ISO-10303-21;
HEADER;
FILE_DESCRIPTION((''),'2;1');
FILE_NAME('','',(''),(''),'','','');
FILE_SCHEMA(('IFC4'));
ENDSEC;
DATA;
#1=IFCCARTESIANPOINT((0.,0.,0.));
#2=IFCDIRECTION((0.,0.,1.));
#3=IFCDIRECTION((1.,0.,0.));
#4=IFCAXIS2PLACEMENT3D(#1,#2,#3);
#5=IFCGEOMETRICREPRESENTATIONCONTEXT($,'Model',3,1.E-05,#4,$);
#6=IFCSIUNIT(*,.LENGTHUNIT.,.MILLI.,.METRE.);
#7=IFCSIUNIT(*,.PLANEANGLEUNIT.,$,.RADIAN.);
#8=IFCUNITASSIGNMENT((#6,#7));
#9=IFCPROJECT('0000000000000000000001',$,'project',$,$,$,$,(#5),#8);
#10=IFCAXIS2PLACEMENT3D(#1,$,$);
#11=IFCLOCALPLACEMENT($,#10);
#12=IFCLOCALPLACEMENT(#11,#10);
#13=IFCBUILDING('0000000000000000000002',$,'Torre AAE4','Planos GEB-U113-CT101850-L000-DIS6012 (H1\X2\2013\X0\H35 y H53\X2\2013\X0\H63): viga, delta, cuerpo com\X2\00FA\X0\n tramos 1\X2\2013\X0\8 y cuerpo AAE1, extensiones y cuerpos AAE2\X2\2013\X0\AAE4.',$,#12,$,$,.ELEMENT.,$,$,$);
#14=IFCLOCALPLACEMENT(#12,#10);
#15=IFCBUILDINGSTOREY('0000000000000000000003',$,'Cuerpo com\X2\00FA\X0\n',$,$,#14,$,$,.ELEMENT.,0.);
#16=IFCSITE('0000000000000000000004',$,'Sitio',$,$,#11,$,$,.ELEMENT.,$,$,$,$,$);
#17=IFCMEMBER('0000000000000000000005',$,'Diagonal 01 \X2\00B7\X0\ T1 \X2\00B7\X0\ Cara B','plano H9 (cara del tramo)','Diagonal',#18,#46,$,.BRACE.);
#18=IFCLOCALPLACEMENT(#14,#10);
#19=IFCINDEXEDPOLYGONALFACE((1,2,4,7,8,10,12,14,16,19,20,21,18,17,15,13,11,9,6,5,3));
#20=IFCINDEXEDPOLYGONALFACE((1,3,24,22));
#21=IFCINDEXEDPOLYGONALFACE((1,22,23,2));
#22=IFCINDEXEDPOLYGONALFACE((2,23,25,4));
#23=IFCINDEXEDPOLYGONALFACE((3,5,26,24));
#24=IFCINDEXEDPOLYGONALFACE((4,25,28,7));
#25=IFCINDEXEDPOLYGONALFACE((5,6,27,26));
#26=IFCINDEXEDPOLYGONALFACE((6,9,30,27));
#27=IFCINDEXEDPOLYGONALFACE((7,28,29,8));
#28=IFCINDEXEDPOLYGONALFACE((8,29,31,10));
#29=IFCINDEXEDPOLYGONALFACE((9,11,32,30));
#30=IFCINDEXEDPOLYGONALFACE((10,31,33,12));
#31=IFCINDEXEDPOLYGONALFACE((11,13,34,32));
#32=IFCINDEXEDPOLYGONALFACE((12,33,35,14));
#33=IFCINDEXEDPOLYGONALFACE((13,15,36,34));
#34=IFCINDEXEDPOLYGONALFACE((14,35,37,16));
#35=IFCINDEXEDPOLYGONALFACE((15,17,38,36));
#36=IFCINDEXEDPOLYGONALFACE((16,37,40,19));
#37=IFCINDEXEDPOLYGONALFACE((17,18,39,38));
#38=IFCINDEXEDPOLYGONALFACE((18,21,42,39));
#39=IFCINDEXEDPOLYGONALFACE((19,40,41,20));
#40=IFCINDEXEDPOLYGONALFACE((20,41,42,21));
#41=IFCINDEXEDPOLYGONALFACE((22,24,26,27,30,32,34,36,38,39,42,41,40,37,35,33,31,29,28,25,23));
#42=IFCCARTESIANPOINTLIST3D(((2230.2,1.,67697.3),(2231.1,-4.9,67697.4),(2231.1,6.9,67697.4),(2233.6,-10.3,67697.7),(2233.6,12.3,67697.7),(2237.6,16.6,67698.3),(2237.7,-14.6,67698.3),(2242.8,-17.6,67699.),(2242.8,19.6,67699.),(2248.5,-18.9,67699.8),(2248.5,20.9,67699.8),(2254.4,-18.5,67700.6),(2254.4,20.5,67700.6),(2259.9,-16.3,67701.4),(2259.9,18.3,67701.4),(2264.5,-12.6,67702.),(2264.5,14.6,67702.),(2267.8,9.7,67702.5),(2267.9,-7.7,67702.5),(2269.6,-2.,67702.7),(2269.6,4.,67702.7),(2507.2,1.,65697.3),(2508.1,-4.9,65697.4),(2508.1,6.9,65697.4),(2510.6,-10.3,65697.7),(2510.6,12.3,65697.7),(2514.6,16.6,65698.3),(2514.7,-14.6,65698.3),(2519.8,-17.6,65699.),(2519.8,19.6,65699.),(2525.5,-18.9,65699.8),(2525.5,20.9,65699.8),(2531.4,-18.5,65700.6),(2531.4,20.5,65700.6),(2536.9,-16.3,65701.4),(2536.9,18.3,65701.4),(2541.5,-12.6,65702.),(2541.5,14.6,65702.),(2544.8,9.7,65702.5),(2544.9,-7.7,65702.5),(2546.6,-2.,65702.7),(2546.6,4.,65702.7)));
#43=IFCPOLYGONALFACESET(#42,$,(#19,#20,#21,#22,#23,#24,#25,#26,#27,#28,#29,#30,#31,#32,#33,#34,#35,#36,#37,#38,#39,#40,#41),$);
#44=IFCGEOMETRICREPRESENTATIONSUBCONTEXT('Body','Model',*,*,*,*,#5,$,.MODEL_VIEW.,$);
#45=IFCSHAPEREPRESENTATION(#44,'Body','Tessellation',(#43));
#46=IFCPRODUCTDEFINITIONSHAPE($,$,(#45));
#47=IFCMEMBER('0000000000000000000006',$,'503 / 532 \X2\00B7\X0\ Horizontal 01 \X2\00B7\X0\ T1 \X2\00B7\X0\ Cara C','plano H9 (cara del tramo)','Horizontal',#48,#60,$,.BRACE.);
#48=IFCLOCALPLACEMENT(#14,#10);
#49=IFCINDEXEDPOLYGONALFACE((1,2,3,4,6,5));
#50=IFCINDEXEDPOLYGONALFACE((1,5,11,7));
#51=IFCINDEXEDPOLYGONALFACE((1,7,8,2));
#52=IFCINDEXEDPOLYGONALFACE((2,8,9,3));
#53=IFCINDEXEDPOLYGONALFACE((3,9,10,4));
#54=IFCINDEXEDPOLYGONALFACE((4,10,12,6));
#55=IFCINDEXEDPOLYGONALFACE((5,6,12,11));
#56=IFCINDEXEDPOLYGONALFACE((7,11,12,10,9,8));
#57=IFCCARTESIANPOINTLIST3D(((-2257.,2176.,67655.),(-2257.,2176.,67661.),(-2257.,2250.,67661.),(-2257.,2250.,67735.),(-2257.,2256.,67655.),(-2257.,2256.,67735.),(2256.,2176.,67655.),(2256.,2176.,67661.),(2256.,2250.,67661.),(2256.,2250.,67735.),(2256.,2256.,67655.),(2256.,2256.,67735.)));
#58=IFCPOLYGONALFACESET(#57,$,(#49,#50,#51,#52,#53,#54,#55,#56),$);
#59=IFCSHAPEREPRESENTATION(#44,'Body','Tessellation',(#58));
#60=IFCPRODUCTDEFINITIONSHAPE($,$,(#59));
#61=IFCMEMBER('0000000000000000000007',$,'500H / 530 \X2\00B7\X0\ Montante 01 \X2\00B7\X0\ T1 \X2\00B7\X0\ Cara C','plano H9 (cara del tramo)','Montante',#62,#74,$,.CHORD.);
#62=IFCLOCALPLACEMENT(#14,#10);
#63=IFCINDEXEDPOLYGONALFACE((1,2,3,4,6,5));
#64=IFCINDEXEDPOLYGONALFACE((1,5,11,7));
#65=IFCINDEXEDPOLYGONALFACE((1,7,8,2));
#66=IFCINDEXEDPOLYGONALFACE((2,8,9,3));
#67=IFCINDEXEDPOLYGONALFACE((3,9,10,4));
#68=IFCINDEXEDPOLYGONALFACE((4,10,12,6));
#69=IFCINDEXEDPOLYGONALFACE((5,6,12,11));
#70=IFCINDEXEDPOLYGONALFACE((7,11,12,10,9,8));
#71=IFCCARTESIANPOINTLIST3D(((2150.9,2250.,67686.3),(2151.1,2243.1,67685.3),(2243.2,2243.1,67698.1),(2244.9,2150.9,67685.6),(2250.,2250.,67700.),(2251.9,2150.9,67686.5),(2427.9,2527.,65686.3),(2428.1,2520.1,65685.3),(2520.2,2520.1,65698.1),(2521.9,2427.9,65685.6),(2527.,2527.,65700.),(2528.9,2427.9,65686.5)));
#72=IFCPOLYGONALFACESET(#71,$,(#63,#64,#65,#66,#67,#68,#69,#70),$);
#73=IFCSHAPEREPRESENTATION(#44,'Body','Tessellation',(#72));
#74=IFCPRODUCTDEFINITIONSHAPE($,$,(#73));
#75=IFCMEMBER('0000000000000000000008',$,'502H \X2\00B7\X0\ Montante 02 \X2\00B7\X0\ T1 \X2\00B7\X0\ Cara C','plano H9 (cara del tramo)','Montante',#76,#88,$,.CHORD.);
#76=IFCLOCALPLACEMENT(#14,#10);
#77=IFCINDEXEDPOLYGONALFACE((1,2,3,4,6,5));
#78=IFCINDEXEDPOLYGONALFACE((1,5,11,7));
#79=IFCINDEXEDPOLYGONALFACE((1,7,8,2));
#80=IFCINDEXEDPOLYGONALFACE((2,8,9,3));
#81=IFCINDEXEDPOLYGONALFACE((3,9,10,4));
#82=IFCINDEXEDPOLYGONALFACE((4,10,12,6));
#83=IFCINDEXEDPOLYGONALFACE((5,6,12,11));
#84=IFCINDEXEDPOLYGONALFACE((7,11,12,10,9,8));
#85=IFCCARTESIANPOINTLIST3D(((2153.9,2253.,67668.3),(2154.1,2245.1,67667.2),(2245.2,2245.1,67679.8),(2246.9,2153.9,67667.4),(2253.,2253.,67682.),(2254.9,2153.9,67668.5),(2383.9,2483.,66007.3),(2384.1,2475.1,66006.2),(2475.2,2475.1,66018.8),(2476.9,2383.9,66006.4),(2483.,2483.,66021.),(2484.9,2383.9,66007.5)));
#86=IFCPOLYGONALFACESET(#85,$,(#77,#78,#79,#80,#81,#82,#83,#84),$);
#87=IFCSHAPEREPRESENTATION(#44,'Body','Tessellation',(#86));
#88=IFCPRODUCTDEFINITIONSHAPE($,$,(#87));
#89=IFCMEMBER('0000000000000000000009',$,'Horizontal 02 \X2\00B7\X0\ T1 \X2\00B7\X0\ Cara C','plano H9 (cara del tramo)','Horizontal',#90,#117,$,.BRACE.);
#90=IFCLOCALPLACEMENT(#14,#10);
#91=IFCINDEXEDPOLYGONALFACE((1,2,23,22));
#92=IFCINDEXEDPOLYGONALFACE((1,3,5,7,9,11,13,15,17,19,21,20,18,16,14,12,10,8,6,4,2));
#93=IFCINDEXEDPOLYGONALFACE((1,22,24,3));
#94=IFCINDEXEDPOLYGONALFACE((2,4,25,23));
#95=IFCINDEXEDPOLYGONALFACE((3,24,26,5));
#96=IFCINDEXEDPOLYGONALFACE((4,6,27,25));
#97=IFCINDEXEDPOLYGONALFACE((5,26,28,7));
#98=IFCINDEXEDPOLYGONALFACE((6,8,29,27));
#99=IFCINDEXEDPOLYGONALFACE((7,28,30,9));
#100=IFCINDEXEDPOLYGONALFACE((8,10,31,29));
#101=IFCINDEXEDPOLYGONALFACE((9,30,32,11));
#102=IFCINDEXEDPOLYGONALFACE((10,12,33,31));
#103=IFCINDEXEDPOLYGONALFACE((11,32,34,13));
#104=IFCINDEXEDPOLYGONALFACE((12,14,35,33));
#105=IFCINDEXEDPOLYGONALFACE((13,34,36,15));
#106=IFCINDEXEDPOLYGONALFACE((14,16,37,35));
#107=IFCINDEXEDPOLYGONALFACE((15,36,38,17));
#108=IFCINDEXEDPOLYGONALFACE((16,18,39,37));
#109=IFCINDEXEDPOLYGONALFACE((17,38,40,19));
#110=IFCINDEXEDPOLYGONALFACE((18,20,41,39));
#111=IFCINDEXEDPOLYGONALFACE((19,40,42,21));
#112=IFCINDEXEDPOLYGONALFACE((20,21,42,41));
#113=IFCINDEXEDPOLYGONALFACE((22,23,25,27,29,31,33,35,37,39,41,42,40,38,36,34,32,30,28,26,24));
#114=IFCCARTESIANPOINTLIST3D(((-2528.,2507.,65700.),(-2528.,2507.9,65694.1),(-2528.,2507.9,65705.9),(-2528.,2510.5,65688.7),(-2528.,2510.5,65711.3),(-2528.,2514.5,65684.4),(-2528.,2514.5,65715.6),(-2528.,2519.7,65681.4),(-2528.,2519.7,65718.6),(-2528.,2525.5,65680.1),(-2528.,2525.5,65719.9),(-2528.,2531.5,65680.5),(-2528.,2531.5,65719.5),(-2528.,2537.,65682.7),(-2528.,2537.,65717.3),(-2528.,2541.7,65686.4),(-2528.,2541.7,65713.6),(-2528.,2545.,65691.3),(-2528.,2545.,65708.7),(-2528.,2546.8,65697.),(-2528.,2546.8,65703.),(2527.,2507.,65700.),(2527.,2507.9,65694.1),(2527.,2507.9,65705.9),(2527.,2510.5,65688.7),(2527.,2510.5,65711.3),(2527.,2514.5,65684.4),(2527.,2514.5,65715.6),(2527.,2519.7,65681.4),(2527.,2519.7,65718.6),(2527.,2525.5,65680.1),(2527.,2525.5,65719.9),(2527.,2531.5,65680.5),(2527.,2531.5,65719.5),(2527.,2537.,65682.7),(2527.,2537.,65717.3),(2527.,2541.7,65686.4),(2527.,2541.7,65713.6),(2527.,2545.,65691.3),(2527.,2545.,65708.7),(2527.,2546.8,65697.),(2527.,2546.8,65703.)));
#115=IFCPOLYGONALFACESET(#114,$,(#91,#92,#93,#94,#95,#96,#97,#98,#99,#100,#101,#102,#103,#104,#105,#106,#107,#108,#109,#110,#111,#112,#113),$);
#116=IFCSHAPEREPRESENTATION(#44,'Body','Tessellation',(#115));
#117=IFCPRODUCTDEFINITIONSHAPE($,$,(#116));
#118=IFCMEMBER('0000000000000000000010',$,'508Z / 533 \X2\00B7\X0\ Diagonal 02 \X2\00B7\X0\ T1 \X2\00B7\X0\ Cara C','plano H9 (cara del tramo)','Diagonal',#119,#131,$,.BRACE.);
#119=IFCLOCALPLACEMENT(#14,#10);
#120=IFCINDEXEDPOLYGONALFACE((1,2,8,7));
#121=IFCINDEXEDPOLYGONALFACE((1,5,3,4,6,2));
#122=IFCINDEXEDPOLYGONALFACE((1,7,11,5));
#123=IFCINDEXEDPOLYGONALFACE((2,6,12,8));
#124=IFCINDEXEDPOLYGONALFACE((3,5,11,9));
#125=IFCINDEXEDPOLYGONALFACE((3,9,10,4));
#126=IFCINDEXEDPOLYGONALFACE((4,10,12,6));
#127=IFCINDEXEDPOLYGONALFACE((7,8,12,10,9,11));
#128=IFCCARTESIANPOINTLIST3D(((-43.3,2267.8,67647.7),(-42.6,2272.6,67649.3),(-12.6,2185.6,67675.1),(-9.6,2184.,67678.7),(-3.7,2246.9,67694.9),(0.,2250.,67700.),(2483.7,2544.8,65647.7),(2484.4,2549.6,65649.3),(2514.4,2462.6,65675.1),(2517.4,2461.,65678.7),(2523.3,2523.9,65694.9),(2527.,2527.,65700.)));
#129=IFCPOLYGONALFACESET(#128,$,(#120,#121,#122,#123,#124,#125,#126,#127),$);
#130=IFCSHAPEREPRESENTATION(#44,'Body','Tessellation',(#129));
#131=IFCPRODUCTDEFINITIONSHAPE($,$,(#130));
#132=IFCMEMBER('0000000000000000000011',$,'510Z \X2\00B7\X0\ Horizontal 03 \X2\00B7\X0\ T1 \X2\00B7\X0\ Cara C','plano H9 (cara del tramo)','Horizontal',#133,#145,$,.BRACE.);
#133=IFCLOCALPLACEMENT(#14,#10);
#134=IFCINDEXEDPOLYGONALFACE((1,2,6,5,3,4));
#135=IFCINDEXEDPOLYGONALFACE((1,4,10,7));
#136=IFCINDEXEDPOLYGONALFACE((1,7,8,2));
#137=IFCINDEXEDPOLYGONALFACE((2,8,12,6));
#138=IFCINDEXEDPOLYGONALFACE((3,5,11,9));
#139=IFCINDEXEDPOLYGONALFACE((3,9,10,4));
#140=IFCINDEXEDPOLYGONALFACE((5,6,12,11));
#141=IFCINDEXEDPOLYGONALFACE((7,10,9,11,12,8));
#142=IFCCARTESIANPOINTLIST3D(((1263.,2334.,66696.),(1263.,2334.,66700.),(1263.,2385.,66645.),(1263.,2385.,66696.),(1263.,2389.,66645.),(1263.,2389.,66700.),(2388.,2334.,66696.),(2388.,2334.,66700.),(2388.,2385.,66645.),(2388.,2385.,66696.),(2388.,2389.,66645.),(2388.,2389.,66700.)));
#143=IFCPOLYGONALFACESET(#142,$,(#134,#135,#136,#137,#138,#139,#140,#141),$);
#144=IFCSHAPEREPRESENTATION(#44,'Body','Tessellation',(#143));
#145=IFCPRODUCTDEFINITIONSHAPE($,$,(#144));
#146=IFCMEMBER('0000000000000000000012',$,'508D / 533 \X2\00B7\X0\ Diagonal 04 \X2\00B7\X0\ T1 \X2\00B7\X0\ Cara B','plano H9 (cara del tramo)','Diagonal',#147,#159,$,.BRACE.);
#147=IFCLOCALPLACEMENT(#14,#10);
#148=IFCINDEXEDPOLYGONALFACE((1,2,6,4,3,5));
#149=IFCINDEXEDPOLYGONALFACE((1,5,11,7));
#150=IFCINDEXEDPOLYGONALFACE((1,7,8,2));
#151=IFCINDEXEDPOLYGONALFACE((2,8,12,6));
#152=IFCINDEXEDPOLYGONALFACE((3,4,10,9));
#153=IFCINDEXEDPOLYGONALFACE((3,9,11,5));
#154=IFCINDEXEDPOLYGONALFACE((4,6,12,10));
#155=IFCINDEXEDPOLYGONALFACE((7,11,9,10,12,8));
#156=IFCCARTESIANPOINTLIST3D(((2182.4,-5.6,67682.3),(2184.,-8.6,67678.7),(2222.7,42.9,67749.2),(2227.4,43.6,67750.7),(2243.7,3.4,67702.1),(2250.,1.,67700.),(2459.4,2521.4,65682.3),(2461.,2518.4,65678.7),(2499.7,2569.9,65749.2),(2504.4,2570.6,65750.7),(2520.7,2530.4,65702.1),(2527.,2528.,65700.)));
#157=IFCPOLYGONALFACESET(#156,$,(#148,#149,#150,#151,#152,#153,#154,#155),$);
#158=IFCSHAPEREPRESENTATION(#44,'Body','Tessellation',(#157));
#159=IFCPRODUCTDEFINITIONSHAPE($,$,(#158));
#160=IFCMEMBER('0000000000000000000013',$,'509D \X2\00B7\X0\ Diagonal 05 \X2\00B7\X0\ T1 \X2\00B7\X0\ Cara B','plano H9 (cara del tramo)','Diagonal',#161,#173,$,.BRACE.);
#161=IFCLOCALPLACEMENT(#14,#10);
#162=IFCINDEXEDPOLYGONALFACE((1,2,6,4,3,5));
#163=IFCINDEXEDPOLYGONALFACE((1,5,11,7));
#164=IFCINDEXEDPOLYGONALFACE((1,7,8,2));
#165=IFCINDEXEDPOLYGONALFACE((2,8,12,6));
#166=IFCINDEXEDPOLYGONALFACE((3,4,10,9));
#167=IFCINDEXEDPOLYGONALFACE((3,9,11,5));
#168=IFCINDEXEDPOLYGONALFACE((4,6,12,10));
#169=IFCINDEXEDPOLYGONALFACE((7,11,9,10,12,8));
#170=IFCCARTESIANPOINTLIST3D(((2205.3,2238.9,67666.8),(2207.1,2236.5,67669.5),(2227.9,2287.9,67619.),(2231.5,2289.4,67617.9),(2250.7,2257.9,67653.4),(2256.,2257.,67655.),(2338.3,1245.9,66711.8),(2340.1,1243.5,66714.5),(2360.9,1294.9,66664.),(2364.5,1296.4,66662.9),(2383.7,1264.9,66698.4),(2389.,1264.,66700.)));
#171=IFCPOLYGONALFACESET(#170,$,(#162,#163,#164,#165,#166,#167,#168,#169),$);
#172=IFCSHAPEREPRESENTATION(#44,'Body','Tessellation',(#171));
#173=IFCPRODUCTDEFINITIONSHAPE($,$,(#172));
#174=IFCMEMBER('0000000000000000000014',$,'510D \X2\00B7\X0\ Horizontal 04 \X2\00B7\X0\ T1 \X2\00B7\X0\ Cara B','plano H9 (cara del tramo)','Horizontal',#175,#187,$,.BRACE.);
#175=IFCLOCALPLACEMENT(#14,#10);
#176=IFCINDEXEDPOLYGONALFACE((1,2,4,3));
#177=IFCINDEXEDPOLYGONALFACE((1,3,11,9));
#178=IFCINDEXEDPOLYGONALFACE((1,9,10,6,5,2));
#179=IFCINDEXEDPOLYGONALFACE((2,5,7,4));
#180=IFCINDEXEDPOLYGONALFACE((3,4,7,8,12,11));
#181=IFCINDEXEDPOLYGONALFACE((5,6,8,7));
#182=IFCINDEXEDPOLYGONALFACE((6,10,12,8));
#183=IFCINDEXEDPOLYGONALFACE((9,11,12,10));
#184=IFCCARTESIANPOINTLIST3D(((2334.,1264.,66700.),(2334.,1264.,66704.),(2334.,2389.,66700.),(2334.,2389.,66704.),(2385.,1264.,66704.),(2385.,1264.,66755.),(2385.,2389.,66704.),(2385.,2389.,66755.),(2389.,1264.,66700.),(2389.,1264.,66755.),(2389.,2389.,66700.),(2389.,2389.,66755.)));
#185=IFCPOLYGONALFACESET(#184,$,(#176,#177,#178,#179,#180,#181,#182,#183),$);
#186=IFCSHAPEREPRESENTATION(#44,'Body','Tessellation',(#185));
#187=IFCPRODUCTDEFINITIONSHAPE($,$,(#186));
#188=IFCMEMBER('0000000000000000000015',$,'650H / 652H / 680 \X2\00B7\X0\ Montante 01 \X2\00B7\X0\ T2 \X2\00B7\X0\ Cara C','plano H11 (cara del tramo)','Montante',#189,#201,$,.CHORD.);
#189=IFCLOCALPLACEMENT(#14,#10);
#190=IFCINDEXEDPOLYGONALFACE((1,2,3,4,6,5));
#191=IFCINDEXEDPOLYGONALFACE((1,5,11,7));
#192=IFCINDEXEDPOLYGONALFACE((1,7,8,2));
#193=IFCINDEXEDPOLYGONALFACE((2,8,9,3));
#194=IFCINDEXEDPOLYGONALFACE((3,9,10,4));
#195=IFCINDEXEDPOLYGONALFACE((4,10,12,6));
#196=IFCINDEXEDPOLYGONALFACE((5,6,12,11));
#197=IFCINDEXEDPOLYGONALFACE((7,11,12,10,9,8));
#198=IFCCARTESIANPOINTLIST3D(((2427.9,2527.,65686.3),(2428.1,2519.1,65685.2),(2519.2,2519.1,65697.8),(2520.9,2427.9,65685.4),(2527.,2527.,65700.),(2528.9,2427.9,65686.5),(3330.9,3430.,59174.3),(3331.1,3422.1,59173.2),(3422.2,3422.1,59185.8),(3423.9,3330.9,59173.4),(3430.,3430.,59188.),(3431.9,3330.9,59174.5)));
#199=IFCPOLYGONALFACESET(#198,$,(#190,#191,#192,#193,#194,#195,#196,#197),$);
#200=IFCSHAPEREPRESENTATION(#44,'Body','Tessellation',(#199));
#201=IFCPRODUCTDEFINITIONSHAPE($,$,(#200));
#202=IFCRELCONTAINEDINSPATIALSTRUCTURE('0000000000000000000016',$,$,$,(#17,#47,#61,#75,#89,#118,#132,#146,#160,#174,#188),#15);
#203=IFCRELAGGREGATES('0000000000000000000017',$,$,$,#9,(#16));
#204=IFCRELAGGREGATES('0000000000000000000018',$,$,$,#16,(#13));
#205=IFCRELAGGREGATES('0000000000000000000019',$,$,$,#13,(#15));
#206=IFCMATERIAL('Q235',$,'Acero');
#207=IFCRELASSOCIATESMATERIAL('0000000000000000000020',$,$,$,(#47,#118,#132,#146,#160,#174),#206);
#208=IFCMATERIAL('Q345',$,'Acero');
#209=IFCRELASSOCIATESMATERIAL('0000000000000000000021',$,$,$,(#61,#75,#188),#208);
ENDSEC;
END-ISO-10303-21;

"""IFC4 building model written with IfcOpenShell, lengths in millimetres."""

from ifc_helpers import new_model, si_unit, frame, frame_2d, origin, origin_with_axes, place, context, subcontext, project, spatial, circle, l_section, extrude, material, element, save


model = new_model("IFC4")

# Units and contexts
model_context = context("Model", 3, precision=1e-05, world=origin_with_axes())
body_context = subcontext(model_context, "Body", "Model", "MODEL_VIEW")
ifc_project = project(units=[si_unit("LENGTHUNIT", "METRE", prefix="MILLI"), si_unit("PLANEANGLEUNIT", "RADIAN")], contexts=[model_context])

# Site, building, storey
site_placement = place(None, origin())
site = spatial("IfcSite", under=ifc_project, at=site_placement, Name="Sitio", CompositionType="ELEMENT")
building_placement = place(site_placement, origin())
building = spatial("IfcBuilding", under=site, at=building_placement, Name="Torre AAE4", Description="Planos GEB-U113-CT101850-L000-DIS6012 (H1–H35 y H53–H63): viga, delta, cuerpo común tramos 1–8 y cuerpo AAE1, extensiones y cuerpos AAE2–AAE4.", CompositionType="ELEMENT")
storey_placement = place(building_placement, origin())
storey = spatial("IfcBuildingStorey", under=building, at=storey_placement, Name="Cuerpo común", CompositionType="ELEMENT", Elevation=0.0)

# Members
member_1_placement = place(storey_placement, frame((2527.0, 1.0, 65700.0), z_axis=(-0.13719, 0.0, 0.990545), x_axis=(-0.990545, -0.000423, -0.13719)))
element("IfcMember", 1, at=member_1_placement, inside=storey, Name="Diagonal 01 · T1 · Cara B", Description="plano H9 (cara del tramo)", ObjectType="Diagonal", PredefinedType="BRACE", context=body_context, shape_type="SweptSolid", body=[
    extrude(circle(Radius=20.0), None, (0.0, 0.0, 1.0), 2019.1),
])
ifc_material_1 = material(Name="Q235", Category="Acero")
member_2_placement = place(storey_placement, frame((2256.0, 2256.0, 67655.0), z_axis=(-1.0, 0.0, 0.0), x_axis=(0.0, -1.0, 0.0)))
element("IfcMember", 2, at=member_2_placement, inside=storey, material=ifc_material_1, Name="503 / 532 · Horizontal 01 · T1 · Cara C", Description="plano H9 (cara del tramo)", ObjectType="Horizontal", PredefinedType="BRACE", context=body_context, shape_type="SweptSolid", body=[
    extrude(l_section(Depth=80.0, Width=80.0, Thickness=6.0, at=frame_2d((40.0, 40.0))), None, (0.0, 0.0, 1.0), 4513.0),
])
ifc_material_2 = material(Name="Q345", Category="Acero")
member_3_placement = place(storey_placement, frame((2250.0, 2250.0, 67700.0), z_axis=(0.135917, 0.135917, -0.981353), x_axis=(0.018647, -0.99072, -0.134632)))
element("IfcMember", 3, at=member_3_placement, inside=storey, material=ifc_material_2, Name="500H / 530 · Montante 01 · T1 · Cara C", Description="plano H9 (cara del tramo)", ObjectType="Montante", PredefinedType="CHORD", context=body_context, shape_type="SweptSolid", body=[
    extrude(l_section(Depth=100.0, Width=100.0, Thickness=7.0, at=frame_2d((50.0, 50.0))), None, (0.0, 0.0, 1.0), 2038.0),
])
member_4_placement = place(storey_placement, frame((2253.0, 2253.0, 67682.0), z_axis=(0.13589, 0.13589, -0.98136), x_axis=(0.018639, -0.990724, -0.134605)))
element("IfcMember", 4, at=member_4_placement, inside=storey, material=ifc_material_2, Name="502H · Montante 02 · T1 · Cara C", Description="plano H9 (cara del tramo)", ObjectType="Montante", PredefinedType="CHORD", context=body_context, shape_type="SweptSolid", body=[
    extrude(l_section(Depth=100.0, Width=100.0, Thickness=8.0, at=frame_2d((50.0, 50.0))), None, (0.0, 0.0, 1.0), 1692.5),
])
member_5_placement = place(storey_placement, frame((2527.0, 2527.0, 65700.0), z_axis=(-1.0, 0.0, 0.0), x_axis=(0.0, -1.0, 0.0)))
element("IfcMember", 5, at=member_5_placement, inside=storey, Name="Horizontal 02 · T1 · Cara C", Description="plano H9 (cara del tramo)", ObjectType="Horizontal", PredefinedType="BRACE", context=body_context, shape_type="SweptSolid", body=[
    extrude(circle(Radius=20.0), None, (0.0, 0.0, 1.0), 5055.0),
])
member_6_placement = place(storey_placement, frame((0.0, 2250.0, 67700.0), z_axis=(0.781247, 0.085637, -0.61832), x_axis=(-0.137116, -0.942809, -0.303825)))
element("IfcMember", 6, at=member_6_placement, inside=storey, material=ifc_material_1, Name="508Z / 533 · Diagonal 02 · T1 · Cara C", Description="plano H9 (cara del tramo)", ObjectType="Diagonal", PredefinedType="BRACE", context=body_context, shape_type="SweptSolid", body=[
    extrude(l_section(Depth=70.0, Width=70.0, Thickness=5.0, at=frame_2d((35.0, 35.0))), None, (0.0, 0.0, 1.0), 3234.6),
])
member_7_placement = place(storey_placement, frame((1263.0, 2389.0, 66700.0), z_axis=(1.0, 0.0, 0.0), x_axis=(0.0, -1.0, 0.0)))
element("IfcMember", 7, at=member_7_placement, inside=storey, material=ifc_material_1, Name="510Z · Horizontal 03 · T1 · Cara C", Description="plano H9 (cara del tramo)", ObjectType="Horizontal", PredefinedType="BRACE", context=body_context, shape_type="SweptSolid", body=[
    extrude(l_section(Depth=55.0, Width=55.0, Thickness=4.0, at=frame_2d((27.5, 27.5))), None, (0.0, 0.0, 1.0), 1125.0),
])
member_8_placement = place(storey_placement, frame((2250.0, 1.0, 67700.0), z_axis=(0.085637, 0.781247, -0.61832), x_axis=(-0.942728, -0.137269, -0.304007)))
element("IfcMember", 8, at=member_8_placement, inside=storey, material=ifc_material_1, Name="508D / 533 · Diagonal 04 · T1 · Cara B", Description="plano H9 (cara del tramo)", ObjectType="Diagonal", PredefinedType="BRACE", context=body_context, shape_type="SweptSolid", body=[
    extrude(l_section(Depth=70.0, Width=70.0, Thickness=5.0, at=frame_2d((35.0, 35.0))), None, (0.0, 0.0, 1.0), 3234.6),
])
member_9_placement = place(storey_placement, frame((2256.0, 2257.0, 67655.0), z_axis=(0.096091, -0.717428, -0.689974), x_axis=(-0.889775, -0.372625, 0.263535)))
element("IfcMember", 9, at=member_9_placement, inside=storey, material=ifc_material_1, Name="509D · Diagonal 05 · T1 · Cara B", Description="plano H9 (cara del tramo)", ObjectType="Diagonal", PredefinedType="BRACE", context=body_context, shape_type="SweptSolid", body=[
    extrude(l_section(Depth=55.0, Width=55.0, Thickness=4.0, at=frame_2d((27.5, 27.5))), None, (0.0, 0.0, 1.0), 1384.1),
])
member_10_placement = place(storey_placement, frame((2389.0, 1264.0, 66700.0), z_axis=(0.0, 1.0, 0.0), x_axis=(-1.0, 0.0, 0.0)))
element("IfcMember", 10, at=member_10_placement, inside=storey, material=ifc_material_1, Name="510D · Horizontal 04 · T1 · Cara B", Description="plano H9 (cara del tramo)", ObjectType="Horizontal", PredefinedType="BRACE", context=body_context, shape_type="SweptSolid", body=[
    extrude(l_section(Depth=55.0, Width=55.0, Thickness=4.0, at=frame_2d((27.5, 27.5))), None, (0.0, 0.0, 1.0), 1125.0),
])
member_11_placement = place(storey_placement, frame((2527.0, 2527.0, 65700.0), z_axis=(0.136075, 0.136075, -0.981309), x_axis=(0.01869, -0.990699, -0.134786)))
element("IfcMember", 11, at=member_11_placement, inside=storey, material=ifc_material_2, Name="650H / 652H / 680 · Montante 01 · T2 · Cara C", Description="plano H11 (cara del tramo)", ObjectType="Montante", PredefinedType="CHORD", context=body_context, shape_type="SweptSolid", body=[
    extrude(l_section(Depth=100.0, Width=100.0, Thickness=8.0, at=frame_2d((50.0, 50.0))), None, (0.0, 0.0, 1.0), 6636.0),
])

save(model, "model.ifc")
